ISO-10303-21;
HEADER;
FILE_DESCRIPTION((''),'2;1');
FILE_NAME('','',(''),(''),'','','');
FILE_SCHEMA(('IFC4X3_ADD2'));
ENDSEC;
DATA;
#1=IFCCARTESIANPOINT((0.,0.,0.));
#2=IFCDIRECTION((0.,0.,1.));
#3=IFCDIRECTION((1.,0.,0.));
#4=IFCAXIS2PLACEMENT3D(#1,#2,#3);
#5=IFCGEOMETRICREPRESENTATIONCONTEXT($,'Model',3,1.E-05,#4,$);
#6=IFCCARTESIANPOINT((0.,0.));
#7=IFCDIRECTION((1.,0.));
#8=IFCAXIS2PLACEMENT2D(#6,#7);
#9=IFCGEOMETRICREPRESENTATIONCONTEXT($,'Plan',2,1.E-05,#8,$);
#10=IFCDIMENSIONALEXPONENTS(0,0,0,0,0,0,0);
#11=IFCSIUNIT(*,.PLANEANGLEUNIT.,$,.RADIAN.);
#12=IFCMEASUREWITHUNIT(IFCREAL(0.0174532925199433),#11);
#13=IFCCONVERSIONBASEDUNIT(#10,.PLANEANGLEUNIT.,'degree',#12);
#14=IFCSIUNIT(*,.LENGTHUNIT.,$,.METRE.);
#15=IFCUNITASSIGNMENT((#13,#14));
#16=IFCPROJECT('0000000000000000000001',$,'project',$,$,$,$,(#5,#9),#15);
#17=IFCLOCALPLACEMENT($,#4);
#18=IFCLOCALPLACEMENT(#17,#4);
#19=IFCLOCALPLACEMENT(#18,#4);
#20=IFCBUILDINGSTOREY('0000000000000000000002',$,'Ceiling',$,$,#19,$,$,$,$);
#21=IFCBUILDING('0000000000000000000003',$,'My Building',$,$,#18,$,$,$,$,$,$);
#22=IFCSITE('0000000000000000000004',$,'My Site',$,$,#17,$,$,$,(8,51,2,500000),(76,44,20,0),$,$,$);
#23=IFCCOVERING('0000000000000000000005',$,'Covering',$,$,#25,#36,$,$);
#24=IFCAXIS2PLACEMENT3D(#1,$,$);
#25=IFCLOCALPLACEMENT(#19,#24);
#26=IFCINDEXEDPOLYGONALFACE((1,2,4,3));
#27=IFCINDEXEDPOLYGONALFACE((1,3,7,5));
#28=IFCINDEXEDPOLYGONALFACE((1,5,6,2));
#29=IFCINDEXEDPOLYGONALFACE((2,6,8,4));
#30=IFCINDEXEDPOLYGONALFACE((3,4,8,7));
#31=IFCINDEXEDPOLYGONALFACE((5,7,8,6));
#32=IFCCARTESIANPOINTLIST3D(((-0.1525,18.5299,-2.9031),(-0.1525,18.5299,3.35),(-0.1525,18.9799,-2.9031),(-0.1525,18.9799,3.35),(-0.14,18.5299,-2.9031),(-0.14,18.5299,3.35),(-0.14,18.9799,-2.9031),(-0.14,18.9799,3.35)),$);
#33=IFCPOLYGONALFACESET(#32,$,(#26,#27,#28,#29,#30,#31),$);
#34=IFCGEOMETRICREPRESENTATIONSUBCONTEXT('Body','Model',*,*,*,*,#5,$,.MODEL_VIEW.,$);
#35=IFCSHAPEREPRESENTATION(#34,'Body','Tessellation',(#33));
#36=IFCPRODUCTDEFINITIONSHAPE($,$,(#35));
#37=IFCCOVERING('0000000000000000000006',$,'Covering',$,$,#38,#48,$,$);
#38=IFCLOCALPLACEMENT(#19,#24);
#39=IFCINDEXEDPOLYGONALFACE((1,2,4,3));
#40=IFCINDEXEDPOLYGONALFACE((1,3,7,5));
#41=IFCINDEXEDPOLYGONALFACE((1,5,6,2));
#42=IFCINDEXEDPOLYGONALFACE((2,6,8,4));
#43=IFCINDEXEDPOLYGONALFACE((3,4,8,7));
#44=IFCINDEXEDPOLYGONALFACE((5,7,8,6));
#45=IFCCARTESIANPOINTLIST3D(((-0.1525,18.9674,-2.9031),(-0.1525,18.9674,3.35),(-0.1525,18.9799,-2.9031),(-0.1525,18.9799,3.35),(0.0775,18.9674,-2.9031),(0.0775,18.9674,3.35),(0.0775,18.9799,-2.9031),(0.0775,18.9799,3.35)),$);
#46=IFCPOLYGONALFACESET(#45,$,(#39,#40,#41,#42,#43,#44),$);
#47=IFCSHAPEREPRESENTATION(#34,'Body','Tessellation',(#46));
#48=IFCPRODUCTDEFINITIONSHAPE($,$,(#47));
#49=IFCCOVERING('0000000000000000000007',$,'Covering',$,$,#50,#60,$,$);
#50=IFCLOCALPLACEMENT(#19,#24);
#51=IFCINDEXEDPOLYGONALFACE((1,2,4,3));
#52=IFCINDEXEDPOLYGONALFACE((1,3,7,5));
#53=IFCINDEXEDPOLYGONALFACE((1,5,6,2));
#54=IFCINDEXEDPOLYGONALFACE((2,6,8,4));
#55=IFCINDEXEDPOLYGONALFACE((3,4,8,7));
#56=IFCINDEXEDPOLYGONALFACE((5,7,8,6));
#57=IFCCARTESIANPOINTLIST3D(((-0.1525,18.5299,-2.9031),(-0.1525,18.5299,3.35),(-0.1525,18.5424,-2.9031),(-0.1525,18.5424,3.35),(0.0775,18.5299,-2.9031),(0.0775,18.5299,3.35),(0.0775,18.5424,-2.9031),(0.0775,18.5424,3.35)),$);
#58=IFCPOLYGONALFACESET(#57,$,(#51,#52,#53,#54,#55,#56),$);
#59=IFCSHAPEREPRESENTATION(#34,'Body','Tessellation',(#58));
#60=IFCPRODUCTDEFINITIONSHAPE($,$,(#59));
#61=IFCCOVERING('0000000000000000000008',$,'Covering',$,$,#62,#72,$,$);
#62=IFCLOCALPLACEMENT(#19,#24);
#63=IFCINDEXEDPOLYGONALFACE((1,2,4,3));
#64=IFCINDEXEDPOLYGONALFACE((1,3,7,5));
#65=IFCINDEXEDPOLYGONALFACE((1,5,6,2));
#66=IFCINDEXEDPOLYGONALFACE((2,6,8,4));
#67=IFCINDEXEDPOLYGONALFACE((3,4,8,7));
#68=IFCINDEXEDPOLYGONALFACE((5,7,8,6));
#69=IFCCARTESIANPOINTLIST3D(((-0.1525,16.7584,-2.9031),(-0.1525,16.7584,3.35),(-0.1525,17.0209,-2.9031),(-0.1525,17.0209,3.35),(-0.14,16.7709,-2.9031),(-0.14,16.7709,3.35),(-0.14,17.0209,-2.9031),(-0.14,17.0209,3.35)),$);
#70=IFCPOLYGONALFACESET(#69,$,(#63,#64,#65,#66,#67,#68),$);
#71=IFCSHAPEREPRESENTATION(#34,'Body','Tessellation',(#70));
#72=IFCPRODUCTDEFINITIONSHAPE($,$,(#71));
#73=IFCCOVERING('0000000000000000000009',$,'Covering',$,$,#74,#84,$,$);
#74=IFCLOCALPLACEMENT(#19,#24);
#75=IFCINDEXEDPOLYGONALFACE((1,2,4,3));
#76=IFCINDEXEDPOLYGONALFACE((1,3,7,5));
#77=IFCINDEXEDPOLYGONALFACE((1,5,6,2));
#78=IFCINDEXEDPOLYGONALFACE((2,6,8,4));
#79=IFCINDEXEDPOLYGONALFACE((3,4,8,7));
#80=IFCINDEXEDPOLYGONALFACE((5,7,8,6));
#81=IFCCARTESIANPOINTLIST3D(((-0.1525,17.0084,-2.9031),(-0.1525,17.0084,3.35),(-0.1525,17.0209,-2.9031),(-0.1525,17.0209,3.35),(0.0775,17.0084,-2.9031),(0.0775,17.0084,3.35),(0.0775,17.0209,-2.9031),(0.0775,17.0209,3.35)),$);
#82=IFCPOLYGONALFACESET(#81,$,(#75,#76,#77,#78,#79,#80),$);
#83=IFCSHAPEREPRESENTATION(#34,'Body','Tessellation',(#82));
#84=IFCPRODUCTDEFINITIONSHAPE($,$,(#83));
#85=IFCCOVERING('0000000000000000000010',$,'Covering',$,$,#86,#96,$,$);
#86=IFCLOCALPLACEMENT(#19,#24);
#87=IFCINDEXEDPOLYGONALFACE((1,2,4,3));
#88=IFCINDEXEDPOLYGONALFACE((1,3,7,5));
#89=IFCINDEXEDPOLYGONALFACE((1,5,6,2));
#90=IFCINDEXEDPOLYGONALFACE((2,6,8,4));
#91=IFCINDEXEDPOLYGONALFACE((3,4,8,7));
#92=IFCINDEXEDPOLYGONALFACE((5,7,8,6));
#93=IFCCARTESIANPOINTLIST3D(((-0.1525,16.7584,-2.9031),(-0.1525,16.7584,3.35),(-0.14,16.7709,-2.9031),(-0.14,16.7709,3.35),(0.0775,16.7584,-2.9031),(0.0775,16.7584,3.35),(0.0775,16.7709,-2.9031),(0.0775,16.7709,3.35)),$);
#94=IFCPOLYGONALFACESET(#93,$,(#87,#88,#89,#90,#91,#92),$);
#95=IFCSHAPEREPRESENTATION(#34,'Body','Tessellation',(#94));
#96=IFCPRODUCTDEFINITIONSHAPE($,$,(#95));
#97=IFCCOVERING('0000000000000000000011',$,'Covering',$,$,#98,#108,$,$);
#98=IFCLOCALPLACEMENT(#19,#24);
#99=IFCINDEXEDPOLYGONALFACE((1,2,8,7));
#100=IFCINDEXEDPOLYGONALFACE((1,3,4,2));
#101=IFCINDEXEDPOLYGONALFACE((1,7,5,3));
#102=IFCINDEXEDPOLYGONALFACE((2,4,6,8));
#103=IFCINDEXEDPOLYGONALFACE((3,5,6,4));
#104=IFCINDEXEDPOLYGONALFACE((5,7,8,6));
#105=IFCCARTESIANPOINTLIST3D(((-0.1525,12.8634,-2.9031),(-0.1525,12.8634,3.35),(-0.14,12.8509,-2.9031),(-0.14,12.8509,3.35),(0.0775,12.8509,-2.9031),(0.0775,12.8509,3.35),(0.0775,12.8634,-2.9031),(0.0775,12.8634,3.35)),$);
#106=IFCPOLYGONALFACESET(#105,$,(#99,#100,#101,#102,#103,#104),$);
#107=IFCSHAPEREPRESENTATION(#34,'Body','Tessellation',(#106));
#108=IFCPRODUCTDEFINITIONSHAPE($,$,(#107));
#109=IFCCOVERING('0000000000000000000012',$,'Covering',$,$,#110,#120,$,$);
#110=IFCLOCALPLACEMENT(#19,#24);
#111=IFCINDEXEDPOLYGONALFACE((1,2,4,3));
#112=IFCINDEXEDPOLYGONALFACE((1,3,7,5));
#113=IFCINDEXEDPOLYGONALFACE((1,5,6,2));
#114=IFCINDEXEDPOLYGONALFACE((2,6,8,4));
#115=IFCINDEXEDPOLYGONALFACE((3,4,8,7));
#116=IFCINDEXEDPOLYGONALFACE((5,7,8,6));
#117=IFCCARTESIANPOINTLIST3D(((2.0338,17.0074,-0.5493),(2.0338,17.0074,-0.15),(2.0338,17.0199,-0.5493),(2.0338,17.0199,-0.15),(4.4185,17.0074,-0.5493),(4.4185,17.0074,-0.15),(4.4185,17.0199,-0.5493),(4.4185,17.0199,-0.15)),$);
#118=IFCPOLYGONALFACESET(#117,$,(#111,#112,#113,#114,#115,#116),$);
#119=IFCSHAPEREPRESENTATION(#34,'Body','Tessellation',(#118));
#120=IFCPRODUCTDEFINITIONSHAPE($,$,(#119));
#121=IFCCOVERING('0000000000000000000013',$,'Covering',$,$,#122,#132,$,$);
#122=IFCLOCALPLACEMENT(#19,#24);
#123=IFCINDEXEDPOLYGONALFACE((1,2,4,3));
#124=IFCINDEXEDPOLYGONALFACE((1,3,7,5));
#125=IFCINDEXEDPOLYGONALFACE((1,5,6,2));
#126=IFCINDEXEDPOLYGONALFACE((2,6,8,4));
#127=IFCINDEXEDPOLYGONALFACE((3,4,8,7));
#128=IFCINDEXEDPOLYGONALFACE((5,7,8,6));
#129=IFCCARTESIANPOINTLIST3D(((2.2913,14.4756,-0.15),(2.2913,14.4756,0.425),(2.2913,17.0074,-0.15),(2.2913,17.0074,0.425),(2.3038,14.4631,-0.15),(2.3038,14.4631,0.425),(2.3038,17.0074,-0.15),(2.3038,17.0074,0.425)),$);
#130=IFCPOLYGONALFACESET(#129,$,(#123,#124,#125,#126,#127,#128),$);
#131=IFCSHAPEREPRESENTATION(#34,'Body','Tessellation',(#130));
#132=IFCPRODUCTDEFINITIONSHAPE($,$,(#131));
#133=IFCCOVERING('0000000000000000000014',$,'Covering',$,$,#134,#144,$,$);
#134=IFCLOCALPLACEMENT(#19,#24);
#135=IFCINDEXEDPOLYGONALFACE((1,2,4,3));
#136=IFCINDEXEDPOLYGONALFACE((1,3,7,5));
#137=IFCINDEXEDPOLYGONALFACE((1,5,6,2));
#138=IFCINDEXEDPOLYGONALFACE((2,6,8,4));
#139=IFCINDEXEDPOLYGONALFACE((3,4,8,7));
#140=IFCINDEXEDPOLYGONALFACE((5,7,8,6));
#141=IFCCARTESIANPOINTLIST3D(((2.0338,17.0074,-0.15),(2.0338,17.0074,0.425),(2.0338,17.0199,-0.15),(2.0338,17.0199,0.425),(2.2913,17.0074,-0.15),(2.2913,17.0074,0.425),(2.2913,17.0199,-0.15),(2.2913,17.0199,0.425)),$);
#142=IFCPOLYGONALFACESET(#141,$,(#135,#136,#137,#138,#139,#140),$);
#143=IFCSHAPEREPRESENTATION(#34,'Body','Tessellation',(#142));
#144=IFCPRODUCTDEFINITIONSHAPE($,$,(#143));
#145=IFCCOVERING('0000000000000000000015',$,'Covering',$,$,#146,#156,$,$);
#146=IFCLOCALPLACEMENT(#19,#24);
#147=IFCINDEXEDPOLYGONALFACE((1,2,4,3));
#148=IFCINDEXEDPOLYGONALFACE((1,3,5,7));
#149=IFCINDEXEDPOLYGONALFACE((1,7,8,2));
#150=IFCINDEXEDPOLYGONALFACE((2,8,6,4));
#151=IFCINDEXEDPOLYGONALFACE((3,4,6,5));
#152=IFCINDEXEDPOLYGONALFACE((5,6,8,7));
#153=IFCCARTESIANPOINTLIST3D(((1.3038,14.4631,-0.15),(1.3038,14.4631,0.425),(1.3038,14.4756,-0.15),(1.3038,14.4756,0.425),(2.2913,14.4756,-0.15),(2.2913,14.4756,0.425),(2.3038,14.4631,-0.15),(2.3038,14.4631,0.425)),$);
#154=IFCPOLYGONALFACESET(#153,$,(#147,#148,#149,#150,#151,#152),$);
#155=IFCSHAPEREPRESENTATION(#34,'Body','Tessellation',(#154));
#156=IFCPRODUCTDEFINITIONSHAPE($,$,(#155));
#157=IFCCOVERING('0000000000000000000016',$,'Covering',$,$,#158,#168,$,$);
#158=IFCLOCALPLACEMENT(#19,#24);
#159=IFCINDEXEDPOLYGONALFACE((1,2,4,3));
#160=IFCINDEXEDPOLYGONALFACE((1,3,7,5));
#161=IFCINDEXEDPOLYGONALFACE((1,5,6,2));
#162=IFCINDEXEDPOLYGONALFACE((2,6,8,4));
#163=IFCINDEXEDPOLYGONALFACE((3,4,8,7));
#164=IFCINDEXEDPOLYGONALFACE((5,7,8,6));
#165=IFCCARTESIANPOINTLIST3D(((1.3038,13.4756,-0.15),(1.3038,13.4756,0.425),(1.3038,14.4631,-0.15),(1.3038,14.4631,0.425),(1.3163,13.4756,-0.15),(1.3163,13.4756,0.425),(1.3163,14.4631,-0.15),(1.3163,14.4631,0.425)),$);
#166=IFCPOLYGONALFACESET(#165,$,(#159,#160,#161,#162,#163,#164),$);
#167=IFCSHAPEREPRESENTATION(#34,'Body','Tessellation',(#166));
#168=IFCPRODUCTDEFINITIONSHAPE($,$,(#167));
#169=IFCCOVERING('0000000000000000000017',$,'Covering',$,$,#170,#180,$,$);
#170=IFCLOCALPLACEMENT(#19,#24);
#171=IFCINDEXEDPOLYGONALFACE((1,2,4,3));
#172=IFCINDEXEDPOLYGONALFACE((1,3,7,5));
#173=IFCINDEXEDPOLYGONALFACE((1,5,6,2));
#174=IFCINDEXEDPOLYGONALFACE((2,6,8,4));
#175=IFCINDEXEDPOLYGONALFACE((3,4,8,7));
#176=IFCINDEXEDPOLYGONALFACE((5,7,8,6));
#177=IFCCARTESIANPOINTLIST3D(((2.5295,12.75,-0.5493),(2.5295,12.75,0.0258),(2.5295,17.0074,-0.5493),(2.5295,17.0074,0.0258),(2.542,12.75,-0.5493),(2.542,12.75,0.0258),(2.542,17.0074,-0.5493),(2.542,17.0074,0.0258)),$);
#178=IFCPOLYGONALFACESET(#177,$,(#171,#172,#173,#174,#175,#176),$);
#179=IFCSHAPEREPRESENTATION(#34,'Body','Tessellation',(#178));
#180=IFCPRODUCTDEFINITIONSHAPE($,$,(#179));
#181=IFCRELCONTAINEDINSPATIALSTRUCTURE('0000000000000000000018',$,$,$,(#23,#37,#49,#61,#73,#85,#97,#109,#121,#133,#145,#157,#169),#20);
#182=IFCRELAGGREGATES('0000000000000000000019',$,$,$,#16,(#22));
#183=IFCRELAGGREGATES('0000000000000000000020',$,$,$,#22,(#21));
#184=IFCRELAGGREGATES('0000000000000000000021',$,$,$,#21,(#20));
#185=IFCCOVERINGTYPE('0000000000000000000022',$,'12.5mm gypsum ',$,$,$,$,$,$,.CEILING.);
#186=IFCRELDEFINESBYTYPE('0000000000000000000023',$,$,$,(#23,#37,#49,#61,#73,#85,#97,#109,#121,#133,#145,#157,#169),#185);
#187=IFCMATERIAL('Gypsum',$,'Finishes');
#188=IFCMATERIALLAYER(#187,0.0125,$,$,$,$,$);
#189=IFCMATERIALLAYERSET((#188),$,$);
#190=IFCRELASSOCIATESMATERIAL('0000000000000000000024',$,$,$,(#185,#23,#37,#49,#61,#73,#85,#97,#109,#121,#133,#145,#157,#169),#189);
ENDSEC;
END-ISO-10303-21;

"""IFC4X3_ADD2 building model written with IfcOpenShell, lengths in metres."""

from ifc_helpers import new_model, entity, si_unit, converted_unit, frame, origin_with_axes, origin_2d_with_axis, place, context, subcontext, project, spatial, line, indexed_curve, outline, extrude, material, layer, layer_set, layer_usage, type_object, element, save


model = new_model("IFC4X3_ADD2")

# Units and contexts
model_context = context("Model", 3, precision=1e-05, world=origin_with_axes())
plan_context = context("Plan", 2, precision=1e-05, world=origin_2d_with_axis())
body_context = subcontext(model_context, "Body", "Model", "MODEL_VIEW")
ifc_project = project(units=[converted_unit("PLANEANGLEUNIT", "degree", entity("IfcReal", 0.0174532925199433), si_unit("PLANEANGLEUNIT", "RADIAN"), dimensions=[0, 0, 0, 0, 0, 0, 0]), si_unit("LENGTHUNIT", "METRE")], contexts=[model_context, plan_context])

# Site, building, storey
site_placement = place(None, origin_with_axes())
site = spatial("IfcSite", under=ifc_project, at=site_placement, Name="My Site", RefLatitude=(8, 51, 2, 500000), RefLongitude=(76, 44, 20, 0))
building_placement = place(site_placement, origin_with_axes())
building = spatial("IfcBuilding", under=site, at=building_placement, Name="My Building")
storey_placement = place(building_placement, origin_with_axes())
storey = spatial("IfcBuildingStorey", under=building, at=storey_placement, Name="Ceiling")

# Coverings
ifc_material_1 = material(Name="Gypsum", Category="Finishes")
ifc_layer_1 = layer(ifc_material_1, 0.0125)
ifc_layer_set_1 = layer_set([ifc_layer_1])
ifc_layer_usage_1 = layer_usage(ifc_layer_set_1, "AXIS2", "POSITIVE", 0.0)
covering_type_1 = type_object("IfcCoveringType", Name="12.5mm gypsum ", PredefinedType="CEILING", material=ifc_layer_set_1)
covering_1_placement = place(storey_placement, frame((-0.14, 18.5299, -2.9031), z_axis=(0.0, 0.0, 1.0), x_axis=(0.0, 1.0, 0.0)))
element("IfcCovering", 1, at=covering_1_placement, inside=storey, type_object=covering_type_1, material=ifc_layer_usage_1, Name="Covering", context=body_context, shape_type="SweptSolid", body=[
    extrude(outline(indexed_curve([(0.0, 0.0), (0.0, 0.0125), (0.45, 0.0125), (0.45, 0.0)], segments=[line(1, 2, 3, 4, 1)])), origin_with_axes(), (0.0, 0.0, 1.0), 6.2531),
])
ifc_layer_usage_2 = layer_usage(ifc_layer_set_1, "AXIS2", "POSITIVE", 0.0)
covering_2_placement = place(storey_placement, frame((-0.1525, 18.9674, -2.9031), z_axis=(0.0, 0.0, 1.0), x_axis=(1.0, -0.000001, 0.0)))
element("IfcCovering", 2, at=covering_2_placement, inside=storey, type_object=covering_type_1, material=ifc_layer_usage_2, Name="Covering", context=body_context, shape_type="SweptSolid", body=[
    extrude(outline(indexed_curve([(0.0, 0.0), (0.0, 0.0125), (0.23, 0.0125), (0.23, 0.0)], segments=[line(1, 2, 3, 4, 1)])), origin_with_axes(), (0.0, 0.0, 1.0), 6.2531),
])
ifc_layer_usage_3 = layer_usage(ifc_layer_set_1, "AXIS2", "POSITIVE", 0.0)
covering_3_placement = place(storey_placement, frame((-0.1525, 18.5299, -2.9031), z_axis=(0.0, 0.0, 1.0), x_axis=(1.0, -0.000001, 0.0)))
element("IfcCovering", 3, at=covering_3_placement, inside=storey, type_object=covering_type_1, material=ifc_layer_usage_3, Name="Covering", context=body_context, shape_type="SweptSolid", body=[
    extrude(outline(indexed_curve([(0.0, 0.0), (0.0, 0.0125), (0.23, 0.0125), (0.23, 0.0)], segments=[line(1, 2, 3, 4, 1)])), origin_with_axes(), (0.0, 0.0, 1.0), 6.2531),
])
ifc_layer_usage_4 = layer_usage(ifc_layer_set_1, "AXIS2", "POSITIVE", 0.0)
covering_4_placement = place(storey_placement, frame((-0.14, 16.7584, -2.9031), z_axis=(0.0, 0.0, 1.0), x_axis=(0.0, 1.0, 0.0)))
element("IfcCovering", 4, at=covering_4_placement, inside=storey, type_object=covering_type_1, material=ifc_layer_usage_4, Name="Covering", context=body_context, shape_type="SweptSolid", body=[
    extrude(outline(indexed_curve([(0.0125, 0.0), (0.0, 0.0125), (0.2625, 0.0125), (0.2625, 0.0)], segments=[line(1, 2, 3, 4, 1)])), origin_with_axes(), (0.0, 0.0, 1.0), 6.2531),
])
ifc_layer_usage_5 = layer_usage(ifc_layer_set_1, "AXIS2", "POSITIVE", 0.0)
covering_5_placement = place(storey_placement, frame((-0.1525, 17.0084, -2.9031), z_axis=(0.0, 0.0, 1.0), x_axis=(1.0, -0.000001, 0.0)))
element("IfcCovering", 5, at=covering_5_placement, inside=storey, type_object=covering_type_1, material=ifc_layer_usage_5, Name="Covering", context=body_context, shape_type="SweptSolid", body=[
    extrude(outline(indexed_curve([(0.0, 0.0), (0.0, 0.0125), (0.23, 0.0125), (0.23, 0.0)], segments=[line(1, 2, 3, 4, 1)])), origin_with_axes(), (0.0, 0.0, 1.0), 6.2531),
])
ifc_layer_usage_6 = layer_usage(ifc_layer_set_1, "AXIS2", "POSITIVE", 0.0)
covering_6_placement = place(storey_placement, frame((-0.14, 16.7584, -2.9031), z_axis=(0.0, 0.0, 1.0), x_axis=(1.0, -0.000001, 0.0)))
element("IfcCovering", 6, at=covering_6_placement, inside=storey, type_object=covering_type_1, material=ifc_layer_usage_6, Name="Covering", context=body_context, shape_type="SweptSolid", body=[
    extrude(outline(indexed_curve([(-0.0125, 0.0), (0.0, 0.0125), (0.2175, 0.0125), (0.2175, 0.0)], segments=[line(1, 2, 3, 4, 1)])), origin_with_axes(), (0.0, 0.0, 1.0), 6.2531),
])
ifc_layer_usage_7 = layer_usage(ifc_layer_set_1, "AXIS2", "POSITIVE", 0.0)
covering_7_placement = place(storey_placement, frame((-0.14, 12.8509, -2.9031), z_axis=(0.0, 0.0, 1.0), x_axis=(1.0, -0.000001, 0.0)))
element("IfcCovering", 7, at=covering_7_placement, inside=storey, type_object=covering_type_1, material=ifc_layer_usage_7, Name="Covering", context=body_context, shape_type="SweptSolid", body=[
    extrude(outline(indexed_curve([(0.0, 0.0), (-0.0125, 0.0125), (0.2175, 0.0125), (0.2175, 0.0)], segments=[line(1, 2, 3, 4, 1)])), origin_with_axes(), (0.0, 0.0, 1.0), 6.2531),
])
ifc_layer_usage_8 = layer_usage(ifc_layer_set_1, "AXIS2", "POSITIVE", 0.0)
covering_8_placement = place(storey_placement, frame((4.4185, 17.0199, -0.5493), z_axis=(0.0, 0.0, 1.0), x_axis=(-1.0, 0.0, 0.0)))
element("IfcCovering", 8, at=covering_8_placement, inside=storey, type_object=covering_type_1, material=ifc_layer_usage_8, Name="Covering", context=body_context, shape_type="SweptSolid", body=[
    extrude(outline(indexed_curve([(0.0, 0.0), (0.0, 0.0125), (2.3847, 0.0125), (2.3847, 0.0)], segments=[line(1, 2, 3, 4, 1)])), origin_with_axes(), (0.0, 0.0, 1.0), 0.3993),
])
ifc_layer_usage_9 = layer_usage(ifc_layer_set_1, "AXIS2", "POSITIVE", 0.0)
covering_9_placement = place(storey_placement, frame((2.2913, 17.0074, -0.15), z_axis=(0.0, 0.0, 1.0), x_axis=(-0.000001, -1.0, 0.0)))
element("IfcCovering", 9, at=covering_9_placement, inside=storey, type_object=covering_type_1, material=ifc_layer_usage_9, Name="Covering", context=body_context, shape_type="SweptSolid", body=[
    extrude(outline(indexed_curve([(0.0, 0.0), (0.0, 0.0125), (2.5444, 0.0125), (2.5319, 0.0)], segments=[line(1, 2, 3, 4, 1)])), origin_with_axes(), (0.0, 0.0, 1.0), 0.575),
])
ifc_layer_usage_10 = layer_usage(ifc_layer_set_1, "AXIS2", "POSITIVE", 0.0)
covering_10_placement = place(storey_placement, frame((2.2913, 17.0199, -0.15), z_axis=(0.0, 0.0, 1.0), x_axis=(-1.0, 0.0, 0.0)))
element("IfcCovering", 10, at=covering_10_placement, inside=storey, type_object=covering_type_1, material=ifc_layer_usage_10, Name="Covering", context=body_context, shape_type="SweptSolid", body=[
    extrude(outline(indexed_curve([(0.0, 0.0), (0.0, 0.0125), (0.2575, 0.0125), (0.2575, 0.0)], segments=[line(1, 2, 3, 4, 1)])), origin_with_axes(), (0.0, 0.0, 1.0), 0.575),
])
ifc_layer_usage_11 = layer_usage(ifc_layer_set_1, "AXIS2", "POSITIVE", 0.0)
covering_11_placement = place(storey_placement, frame((1.3038, 14.4631, -0.15), z_axis=(0.0, 0.0, 1.0), x_axis=(1.0, -0.000001, 0.0)))
element("IfcCovering", 11, at=covering_11_placement, inside=storey, type_object=covering_type_1, material=ifc_layer_usage_11, Name="Covering", context=body_context, shape_type="SweptSolid", body=[
    extrude(outline(indexed_curve([(0.0, 0.0), (0.0, 0.0125), (0.9875, 0.0125), (1.0, 0.0)], segments=[line(1, 2, 3, 4, 1)])), origin_with_axes(), (0.0, 0.0, 1.0), 0.575),
])
ifc_layer_usage_12 = layer_usage(ifc_layer_set_1, "AXIS2", "POSITIVE", 0.0)
covering_12_placement = place(storey_placement, frame((1.3038, 14.4631, -0.15), z_axis=(0.0, 0.0, 1.0), x_axis=(-0.000001, -1.0, 0.0)))
element("IfcCovering", 12, at=covering_12_placement, inside=storey, type_object=covering_type_1, material=ifc_layer_usage_12, Name="Covering", context=body_context, shape_type="SweptSolid", body=[
    extrude(outline(indexed_curve([(0.0, 0.0), (0.0, 0.0125), (0.9875, 0.0125), (0.9875, 0.0)], segments=[line(1, 2, 3, 4, 1)])), origin_with_axes(), (0.0, 0.0, 1.0), 0.575),
])
ifc_layer_usage_13 = layer_usage(ifc_layer_set_1, "AXIS2", "POSITIVE", 0.0)
covering_13_placement = place(storey_placement, frame((2.5295, 17.0074, -0.5493), z_axis=(0.0, 0.0, 1.0), x_axis=(-0.000001, -1.0, 0.0)))
element("IfcCovering", 13, at=covering_13_placement, inside=storey, type_object=covering_type_1, material=ifc_layer_usage_13, Name="Covering", context=body_context, shape_type="SweptSolid", body=[
    extrude(outline(indexed_curve([(0.0, 0.0), (0.0, 0.0125), (4.2574, 0.0125), (4.2574, 0.0)], segments=[line(1, 2, 3, 4, 1)])), origin_with_axes(), (0.0, 0.0, 1.0), 0.575),
])

save(model, "model.ifc")
